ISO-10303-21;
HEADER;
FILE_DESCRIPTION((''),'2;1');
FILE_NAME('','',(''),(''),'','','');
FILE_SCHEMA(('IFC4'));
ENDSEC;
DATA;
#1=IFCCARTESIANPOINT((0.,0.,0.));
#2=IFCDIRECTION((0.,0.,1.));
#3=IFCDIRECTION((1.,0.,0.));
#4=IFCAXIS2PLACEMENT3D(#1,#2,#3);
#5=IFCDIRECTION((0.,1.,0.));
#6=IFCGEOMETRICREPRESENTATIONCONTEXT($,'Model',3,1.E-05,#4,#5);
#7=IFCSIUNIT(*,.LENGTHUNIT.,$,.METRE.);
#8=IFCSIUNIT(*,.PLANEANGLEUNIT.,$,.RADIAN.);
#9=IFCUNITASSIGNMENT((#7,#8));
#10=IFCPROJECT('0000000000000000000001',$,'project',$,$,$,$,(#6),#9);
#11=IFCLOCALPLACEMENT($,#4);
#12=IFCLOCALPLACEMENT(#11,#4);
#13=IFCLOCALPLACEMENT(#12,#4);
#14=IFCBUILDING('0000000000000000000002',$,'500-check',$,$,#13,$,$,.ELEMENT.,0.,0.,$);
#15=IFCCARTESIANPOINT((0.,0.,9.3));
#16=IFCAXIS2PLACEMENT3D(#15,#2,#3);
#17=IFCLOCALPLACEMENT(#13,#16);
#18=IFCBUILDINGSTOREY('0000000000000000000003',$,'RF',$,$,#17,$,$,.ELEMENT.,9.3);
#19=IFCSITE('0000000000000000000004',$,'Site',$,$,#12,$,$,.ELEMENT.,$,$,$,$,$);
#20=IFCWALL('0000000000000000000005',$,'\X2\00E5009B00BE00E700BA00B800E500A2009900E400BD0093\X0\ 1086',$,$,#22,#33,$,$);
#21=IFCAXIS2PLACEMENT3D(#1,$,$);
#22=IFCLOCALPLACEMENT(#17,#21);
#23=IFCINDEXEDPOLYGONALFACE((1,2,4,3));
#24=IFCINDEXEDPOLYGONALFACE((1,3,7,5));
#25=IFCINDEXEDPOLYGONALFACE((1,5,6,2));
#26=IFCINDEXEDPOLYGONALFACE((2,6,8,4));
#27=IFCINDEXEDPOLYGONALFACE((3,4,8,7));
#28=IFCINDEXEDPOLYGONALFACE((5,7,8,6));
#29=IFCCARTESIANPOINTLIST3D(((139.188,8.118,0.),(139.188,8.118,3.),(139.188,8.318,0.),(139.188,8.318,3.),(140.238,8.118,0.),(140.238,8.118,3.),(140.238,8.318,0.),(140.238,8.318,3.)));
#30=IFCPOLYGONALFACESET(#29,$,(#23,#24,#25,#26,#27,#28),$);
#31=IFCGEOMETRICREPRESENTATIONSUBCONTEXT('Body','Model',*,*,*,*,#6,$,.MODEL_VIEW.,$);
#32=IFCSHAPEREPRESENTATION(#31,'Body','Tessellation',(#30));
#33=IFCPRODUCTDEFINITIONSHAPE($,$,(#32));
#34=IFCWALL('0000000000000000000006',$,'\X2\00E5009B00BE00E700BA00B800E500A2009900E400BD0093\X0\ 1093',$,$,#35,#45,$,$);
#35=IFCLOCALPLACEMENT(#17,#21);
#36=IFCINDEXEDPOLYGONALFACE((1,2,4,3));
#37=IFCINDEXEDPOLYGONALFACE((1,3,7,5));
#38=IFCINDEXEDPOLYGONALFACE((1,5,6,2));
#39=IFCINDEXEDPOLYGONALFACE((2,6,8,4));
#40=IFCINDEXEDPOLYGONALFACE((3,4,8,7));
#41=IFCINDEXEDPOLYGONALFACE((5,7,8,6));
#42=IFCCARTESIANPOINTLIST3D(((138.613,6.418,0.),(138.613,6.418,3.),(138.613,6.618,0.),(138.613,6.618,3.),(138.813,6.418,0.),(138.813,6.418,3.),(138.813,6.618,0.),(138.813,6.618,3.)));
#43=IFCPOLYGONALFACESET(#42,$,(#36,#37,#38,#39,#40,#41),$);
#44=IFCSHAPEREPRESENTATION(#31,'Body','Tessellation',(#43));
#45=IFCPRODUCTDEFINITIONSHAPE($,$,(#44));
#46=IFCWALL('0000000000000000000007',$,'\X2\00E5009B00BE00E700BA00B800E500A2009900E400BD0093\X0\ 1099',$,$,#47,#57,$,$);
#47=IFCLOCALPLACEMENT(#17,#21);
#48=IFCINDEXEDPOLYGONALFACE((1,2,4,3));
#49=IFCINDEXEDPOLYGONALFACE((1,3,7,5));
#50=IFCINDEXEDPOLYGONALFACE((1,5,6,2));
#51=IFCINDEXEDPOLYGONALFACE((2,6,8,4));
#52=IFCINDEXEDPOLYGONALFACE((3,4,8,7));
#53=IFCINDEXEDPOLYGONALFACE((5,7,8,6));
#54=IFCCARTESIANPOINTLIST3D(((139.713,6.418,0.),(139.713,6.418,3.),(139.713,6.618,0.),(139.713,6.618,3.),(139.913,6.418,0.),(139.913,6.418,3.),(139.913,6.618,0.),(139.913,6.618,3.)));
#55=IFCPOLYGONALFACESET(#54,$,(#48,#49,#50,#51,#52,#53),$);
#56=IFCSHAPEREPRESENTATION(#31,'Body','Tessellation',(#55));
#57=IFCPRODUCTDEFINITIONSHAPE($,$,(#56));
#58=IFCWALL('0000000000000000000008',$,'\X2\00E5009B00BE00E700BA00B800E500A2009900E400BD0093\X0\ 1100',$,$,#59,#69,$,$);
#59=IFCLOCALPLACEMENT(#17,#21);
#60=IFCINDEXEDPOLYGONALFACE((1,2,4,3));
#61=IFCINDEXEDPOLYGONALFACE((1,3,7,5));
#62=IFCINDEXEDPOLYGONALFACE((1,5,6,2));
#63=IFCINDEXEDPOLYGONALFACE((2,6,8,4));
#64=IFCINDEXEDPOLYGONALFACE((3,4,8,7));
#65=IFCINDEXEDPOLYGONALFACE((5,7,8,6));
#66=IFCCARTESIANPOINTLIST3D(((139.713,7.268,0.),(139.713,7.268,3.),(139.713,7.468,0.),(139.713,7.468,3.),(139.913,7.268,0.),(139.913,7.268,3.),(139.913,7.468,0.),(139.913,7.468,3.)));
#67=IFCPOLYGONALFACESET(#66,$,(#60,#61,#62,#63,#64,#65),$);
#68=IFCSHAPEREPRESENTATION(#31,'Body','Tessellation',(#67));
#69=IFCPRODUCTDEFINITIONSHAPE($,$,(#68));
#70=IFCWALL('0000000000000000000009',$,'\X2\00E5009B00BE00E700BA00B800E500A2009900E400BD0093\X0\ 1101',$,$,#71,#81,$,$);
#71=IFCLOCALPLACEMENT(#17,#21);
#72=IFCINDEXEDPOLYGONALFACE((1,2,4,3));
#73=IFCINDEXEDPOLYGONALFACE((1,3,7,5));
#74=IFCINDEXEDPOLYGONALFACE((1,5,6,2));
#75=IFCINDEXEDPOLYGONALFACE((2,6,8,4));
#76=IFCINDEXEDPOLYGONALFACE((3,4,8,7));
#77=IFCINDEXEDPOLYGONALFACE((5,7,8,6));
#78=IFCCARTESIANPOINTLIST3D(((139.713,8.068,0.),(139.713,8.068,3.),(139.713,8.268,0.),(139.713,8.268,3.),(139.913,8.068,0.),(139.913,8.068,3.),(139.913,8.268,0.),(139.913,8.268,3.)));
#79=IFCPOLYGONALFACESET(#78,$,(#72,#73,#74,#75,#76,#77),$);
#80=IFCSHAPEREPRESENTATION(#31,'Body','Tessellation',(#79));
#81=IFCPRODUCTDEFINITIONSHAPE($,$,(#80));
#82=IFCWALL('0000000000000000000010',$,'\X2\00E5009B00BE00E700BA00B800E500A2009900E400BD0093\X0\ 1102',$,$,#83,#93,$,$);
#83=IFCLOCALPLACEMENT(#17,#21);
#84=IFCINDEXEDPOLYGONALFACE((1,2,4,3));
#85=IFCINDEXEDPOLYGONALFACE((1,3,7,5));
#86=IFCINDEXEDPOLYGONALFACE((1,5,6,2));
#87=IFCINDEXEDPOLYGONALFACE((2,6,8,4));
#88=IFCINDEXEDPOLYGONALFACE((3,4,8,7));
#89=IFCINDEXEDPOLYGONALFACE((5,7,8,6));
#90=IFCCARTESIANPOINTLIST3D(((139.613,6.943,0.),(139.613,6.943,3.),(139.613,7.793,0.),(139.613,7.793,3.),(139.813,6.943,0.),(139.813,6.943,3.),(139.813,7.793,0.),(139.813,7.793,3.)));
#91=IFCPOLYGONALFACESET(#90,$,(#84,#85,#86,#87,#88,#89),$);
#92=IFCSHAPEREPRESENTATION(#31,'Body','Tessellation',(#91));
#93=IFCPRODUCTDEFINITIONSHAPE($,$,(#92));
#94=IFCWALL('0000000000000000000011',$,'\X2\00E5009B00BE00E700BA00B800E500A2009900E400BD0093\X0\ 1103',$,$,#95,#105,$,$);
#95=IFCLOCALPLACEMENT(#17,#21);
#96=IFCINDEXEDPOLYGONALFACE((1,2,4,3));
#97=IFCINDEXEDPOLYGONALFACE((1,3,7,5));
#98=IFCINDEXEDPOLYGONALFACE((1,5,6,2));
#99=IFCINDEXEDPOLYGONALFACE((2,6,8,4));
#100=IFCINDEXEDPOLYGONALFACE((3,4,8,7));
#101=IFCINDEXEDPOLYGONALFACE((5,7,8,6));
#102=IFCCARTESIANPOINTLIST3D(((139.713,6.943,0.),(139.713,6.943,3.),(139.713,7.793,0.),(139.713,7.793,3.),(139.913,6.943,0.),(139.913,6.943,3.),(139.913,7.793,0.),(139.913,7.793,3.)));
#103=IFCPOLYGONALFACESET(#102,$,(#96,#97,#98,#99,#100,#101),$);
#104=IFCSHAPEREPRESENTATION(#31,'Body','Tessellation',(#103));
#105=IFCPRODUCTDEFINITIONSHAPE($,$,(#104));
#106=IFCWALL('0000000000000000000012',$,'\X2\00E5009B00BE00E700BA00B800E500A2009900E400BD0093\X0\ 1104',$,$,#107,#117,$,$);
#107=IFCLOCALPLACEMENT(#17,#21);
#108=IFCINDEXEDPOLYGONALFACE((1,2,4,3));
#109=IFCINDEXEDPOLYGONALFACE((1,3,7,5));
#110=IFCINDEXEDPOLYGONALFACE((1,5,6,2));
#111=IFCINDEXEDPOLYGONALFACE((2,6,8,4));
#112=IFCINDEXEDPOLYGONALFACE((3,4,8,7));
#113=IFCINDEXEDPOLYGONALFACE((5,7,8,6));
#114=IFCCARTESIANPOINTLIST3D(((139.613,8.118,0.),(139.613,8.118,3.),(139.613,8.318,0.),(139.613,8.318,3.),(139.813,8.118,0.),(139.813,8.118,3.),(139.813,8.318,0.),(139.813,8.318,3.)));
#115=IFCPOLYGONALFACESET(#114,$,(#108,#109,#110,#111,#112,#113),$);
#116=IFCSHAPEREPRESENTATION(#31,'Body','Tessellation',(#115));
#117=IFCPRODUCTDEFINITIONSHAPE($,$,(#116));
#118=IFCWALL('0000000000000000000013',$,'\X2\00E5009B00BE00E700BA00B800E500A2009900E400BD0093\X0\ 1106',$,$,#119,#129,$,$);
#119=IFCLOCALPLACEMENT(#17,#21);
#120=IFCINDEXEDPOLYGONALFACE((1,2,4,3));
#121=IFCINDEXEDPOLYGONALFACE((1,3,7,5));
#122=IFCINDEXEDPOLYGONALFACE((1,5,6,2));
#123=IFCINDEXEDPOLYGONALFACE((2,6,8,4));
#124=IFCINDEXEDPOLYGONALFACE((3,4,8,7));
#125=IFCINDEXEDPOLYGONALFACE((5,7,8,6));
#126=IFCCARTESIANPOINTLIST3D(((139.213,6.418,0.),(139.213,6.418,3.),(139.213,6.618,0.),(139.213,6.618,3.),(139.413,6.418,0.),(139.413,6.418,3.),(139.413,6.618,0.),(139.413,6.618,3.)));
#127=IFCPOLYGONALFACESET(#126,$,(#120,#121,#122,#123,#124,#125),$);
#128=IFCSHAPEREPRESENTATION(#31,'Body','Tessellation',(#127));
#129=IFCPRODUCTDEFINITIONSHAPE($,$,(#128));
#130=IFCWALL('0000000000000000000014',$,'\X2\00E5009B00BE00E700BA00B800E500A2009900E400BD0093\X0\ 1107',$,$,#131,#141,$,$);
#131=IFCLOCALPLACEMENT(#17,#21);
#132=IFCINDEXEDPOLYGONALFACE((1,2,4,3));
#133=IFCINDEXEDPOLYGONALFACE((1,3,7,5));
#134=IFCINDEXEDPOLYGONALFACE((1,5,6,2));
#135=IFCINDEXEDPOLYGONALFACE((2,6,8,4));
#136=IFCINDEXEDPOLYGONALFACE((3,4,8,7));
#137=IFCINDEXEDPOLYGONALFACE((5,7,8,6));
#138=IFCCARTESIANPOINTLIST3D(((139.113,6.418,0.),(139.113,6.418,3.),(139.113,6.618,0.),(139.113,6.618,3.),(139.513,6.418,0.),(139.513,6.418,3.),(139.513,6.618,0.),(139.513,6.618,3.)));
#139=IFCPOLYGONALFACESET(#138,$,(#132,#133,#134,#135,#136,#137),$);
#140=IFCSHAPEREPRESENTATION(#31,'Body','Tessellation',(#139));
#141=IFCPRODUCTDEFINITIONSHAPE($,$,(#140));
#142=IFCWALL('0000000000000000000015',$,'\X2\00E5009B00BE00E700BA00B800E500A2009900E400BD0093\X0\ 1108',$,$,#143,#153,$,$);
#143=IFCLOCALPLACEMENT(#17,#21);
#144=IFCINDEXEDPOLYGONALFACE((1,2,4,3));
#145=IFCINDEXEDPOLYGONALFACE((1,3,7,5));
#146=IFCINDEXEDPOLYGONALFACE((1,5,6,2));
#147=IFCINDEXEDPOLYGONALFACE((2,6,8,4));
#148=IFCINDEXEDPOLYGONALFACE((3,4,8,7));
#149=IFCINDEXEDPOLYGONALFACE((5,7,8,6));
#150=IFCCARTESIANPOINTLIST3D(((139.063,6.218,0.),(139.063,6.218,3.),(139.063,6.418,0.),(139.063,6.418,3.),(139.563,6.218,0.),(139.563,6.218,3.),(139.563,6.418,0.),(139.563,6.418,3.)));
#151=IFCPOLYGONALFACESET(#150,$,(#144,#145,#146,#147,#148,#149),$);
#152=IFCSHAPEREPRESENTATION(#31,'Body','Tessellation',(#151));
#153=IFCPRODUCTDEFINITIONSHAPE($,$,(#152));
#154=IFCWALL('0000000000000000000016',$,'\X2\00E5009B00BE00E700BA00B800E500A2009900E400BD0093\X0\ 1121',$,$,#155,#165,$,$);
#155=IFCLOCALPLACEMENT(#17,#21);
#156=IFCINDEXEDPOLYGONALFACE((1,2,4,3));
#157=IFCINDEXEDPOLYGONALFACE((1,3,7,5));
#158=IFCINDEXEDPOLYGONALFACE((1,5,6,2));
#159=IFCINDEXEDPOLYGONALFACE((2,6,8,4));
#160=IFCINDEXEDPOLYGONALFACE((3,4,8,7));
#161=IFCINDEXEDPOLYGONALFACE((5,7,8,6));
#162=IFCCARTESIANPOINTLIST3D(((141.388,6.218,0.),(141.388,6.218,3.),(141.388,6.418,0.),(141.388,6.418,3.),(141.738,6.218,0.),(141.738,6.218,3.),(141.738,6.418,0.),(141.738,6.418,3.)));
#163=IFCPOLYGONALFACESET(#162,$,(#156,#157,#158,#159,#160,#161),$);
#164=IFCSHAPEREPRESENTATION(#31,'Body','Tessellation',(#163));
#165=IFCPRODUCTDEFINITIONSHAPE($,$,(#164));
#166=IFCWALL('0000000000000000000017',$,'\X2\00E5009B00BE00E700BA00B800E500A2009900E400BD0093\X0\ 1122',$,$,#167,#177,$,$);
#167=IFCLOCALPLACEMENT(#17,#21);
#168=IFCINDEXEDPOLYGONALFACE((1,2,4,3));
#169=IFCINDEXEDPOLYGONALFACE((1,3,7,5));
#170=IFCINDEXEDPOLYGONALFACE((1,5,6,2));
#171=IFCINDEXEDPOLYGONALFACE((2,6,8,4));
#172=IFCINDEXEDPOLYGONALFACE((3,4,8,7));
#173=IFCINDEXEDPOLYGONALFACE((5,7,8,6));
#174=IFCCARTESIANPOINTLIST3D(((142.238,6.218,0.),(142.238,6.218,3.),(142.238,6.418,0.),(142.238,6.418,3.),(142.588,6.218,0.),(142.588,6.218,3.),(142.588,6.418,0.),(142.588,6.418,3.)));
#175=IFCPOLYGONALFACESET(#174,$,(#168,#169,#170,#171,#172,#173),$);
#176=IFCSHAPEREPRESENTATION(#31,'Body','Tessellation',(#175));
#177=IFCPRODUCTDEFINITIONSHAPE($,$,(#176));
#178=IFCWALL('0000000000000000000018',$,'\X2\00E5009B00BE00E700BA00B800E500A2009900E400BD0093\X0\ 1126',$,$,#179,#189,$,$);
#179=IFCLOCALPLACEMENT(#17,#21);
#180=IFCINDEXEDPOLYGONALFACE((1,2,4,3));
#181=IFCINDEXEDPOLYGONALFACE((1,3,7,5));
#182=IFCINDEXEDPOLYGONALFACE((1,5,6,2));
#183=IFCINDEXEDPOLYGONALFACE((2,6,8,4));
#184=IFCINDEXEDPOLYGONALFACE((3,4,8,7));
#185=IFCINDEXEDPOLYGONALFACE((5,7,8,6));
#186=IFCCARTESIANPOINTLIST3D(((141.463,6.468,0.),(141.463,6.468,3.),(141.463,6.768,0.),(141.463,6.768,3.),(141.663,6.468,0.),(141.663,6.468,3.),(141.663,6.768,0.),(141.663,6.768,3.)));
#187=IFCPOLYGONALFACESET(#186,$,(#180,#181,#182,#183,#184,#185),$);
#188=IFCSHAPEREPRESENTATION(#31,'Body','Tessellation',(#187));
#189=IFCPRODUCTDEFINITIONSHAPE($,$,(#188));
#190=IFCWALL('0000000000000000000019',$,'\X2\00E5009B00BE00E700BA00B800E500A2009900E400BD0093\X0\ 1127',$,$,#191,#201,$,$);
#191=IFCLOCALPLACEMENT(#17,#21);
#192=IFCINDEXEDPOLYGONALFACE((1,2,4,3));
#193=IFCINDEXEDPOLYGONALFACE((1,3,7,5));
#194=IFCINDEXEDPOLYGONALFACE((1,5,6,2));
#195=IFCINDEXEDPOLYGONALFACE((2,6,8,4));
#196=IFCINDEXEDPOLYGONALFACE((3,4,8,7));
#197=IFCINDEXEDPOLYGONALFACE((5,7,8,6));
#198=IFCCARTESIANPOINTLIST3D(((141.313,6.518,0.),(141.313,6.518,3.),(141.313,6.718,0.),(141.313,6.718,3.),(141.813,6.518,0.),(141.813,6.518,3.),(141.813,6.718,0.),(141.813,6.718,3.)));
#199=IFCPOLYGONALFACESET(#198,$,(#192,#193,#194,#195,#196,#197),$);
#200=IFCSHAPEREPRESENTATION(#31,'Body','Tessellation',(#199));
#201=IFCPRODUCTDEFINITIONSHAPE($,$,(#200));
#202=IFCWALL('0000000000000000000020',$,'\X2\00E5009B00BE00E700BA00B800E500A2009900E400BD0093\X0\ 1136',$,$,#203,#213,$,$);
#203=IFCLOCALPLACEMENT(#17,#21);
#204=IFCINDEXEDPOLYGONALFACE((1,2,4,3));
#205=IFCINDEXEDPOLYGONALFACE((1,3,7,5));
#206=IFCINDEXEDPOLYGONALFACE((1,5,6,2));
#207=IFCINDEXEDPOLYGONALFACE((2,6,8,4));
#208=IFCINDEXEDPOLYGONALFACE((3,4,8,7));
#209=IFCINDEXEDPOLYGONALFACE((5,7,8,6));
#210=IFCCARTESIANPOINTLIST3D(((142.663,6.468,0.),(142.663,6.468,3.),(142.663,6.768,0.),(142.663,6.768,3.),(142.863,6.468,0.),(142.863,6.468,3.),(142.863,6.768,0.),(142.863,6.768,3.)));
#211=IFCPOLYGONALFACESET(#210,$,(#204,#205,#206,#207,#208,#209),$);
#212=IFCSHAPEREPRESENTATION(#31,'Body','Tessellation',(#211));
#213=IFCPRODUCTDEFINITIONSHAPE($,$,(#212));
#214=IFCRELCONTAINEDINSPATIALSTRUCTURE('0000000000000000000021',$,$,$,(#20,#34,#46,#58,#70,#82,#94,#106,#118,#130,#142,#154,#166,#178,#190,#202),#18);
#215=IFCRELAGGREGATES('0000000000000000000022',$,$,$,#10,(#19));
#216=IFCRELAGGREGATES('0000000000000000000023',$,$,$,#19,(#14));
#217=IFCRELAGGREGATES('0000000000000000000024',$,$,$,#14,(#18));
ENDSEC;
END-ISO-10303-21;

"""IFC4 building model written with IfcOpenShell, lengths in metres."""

from ifc_helpers import new_model, si_unit, direction, frame, frame_2d, origin_with_axes, place, context, subcontext, project, spatial, rectangle, extrude, element, save


model = new_model("IFC4")

# Units and contexts
model_context = context("Model", 3, precision=1e-05, world=origin_with_axes(), true_north=direction((0.0, 1.0, 0.0)))
body_context = subcontext(model_context, "Body", "Model", "MODEL_VIEW")
ifc_project = project(units=[si_unit("LENGTHUNIT", "METRE"), si_unit("PLANEANGLEUNIT", "RADIAN")], contexts=[model_context])

# Site, building, storey
placement = place(None, origin_with_axes())
site_placement = place(placement, origin_with_axes())
site = spatial("IfcSite", under=ifc_project, at=site_placement, Name="Site", CompositionType="ELEMENT")
building_placement = place(site_placement, origin_with_axes())
building = spatial("IfcBuilding", under=site, at=building_placement, Name="500-check", CompositionType="ELEMENT", ElevationOfRefHeight=0.0, ElevationOfTerrain=0.0)
storey_placement = place(building_placement, frame((0.0, 0.0, 9.3), z_axis=(0.0, 0.0, 1.0), x_axis=(1.0, 0.0, 0.0)))
storey = spatial("IfcBuildingStorey", under=building, at=storey_placement, Name="RF", CompositionType="ELEMENT", Elevation=9.3)

# Walls
wall_1_placement = place(storey_placement, frame((139.713, 8.218, 0.0), z_axis=(0.0, 0.0, 1.0), x_axis=(-1.0, 0.0, 0.0)))
element("IfcWall", 1, at=wall_1_placement, inside=storey, Name="å\u009b¾çº¸å¢\u0099ä½\u0093 1086", context=body_context, shape_type="SweptSolid", body=[
    extrude(rectangle(XDim=1.05, YDim=0.2, at=frame_2d((0.0, 0.0), x_axis=(1.0, 0.0, 0.0))), frame((0.0, 0.0, 0.0), z_axis=(0.0, 0.0, 1.0)), (0.0, 0.0, 1.0), 3.0),
])
for number, where, z_axis, x_axis, name in (
    (2, (138.713, 6.518, 0.0), (0.0, 0.0, 1.0), (0.0, -1.0, 0.0), "å\u009b¾çº¸å¢\u0099ä½\u0093 1093"),
    (3, (139.813, 6.518, 0.0), (0.0, 0.0, 1.0), (0.0, -1.0, 0.0), "å\u009b¾çº¸å¢\u0099ä½\u0093 1099"),
    (4, (139.813, 7.368, 0.0), (0.0, 0.0, 1.0), (-1.0, 0.0, 0.0), "å\u009b¾çº¸å¢\u0099ä½\u0093 1100"),
    (5, (139.813, 8.168, 0.0), (0.0, 0.0, 1.0), (-1.0, 0.0, 0.0), "å\u009b¾çº¸å¢\u0099ä½\u0093 1101"),
):
    element("IfcWall", number, at=place(storey_placement, frame(where, z_axis=z_axis, x_axis=x_axis)), inside=storey, Name=name, context=body_context, shape_type="SweptSolid", body=[
        extrude(rectangle(XDim=0.2, YDim=0.2, at=frame_2d((0.0, 0.0), x_axis=(1.0, 0.0, 0.0))), frame((0.0, 0.0, 0.0), z_axis=(0.0, 0.0, 1.0)), (0.0, 0.0, 1.0), 3.0),
    ])
for number, where, z_axis, x_axis, name in (
    (6, (139.713, 7.368, 0.0), (0.0, 0.0, 1.0), (0.0, -1.0, 0.0), "å\u009b¾çº¸å¢\u0099ä½\u0093 1102"),
    (7, (139.813, 7.368, 0.0), (0.0, 0.0, 1.0), (0.0, -1.0, 0.0), "å\u009b¾çº¸å¢\u0099ä½\u0093 1103"),
):
    element("IfcWall", number, at=place(storey_placement, frame(where, z_axis=z_axis, x_axis=x_axis)), inside=storey, Name=name, context=body_context, shape_type="SweptSolid", body=[
        extrude(rectangle(XDim=0.85, YDim=0.2, at=frame_2d((0.0, 0.0), x_axis=(1.0, 0.0, 0.0))), frame((0.0, 0.0, 0.0), z_axis=(0.0, 0.0, 1.0)), (0.0, 0.0, 1.0), 3.0),
    ])
for number, where, z_axis, x_axis, name in (
    (8, (139.713, 8.218, 0.0), (0.0, 0.0, 1.0), (0.0, -1.0, 0.0), "å\u009b¾çº¸å¢\u0099ä½\u0093 1104"),
    (9, (139.313, 6.518, 0.0), (0.0, 0.0, 1.0), (0.0, -1.0, 0.0), "å\u009b¾çº¸å¢\u0099ä½\u0093 1106"),
):
    element("IfcWall", number, at=place(storey_placement, frame(where, z_axis=z_axis, x_axis=x_axis)), inside=storey, Name=name, context=body_context, shape_type="SweptSolid", body=[
        extrude(rectangle(XDim=0.2, YDim=0.2, at=frame_2d((0.0, 0.0), x_axis=(1.0, 0.0, 0.0))), frame((0.0, 0.0, 0.0), z_axis=(0.0, 0.0, 1.0)), (0.0, 0.0, 1.0), 3.0),
    ])
wall_2_placement = place(storey_placement, frame((139.313, 6.518, 0.0), z_axis=(0.0, 0.0, 1.0), x_axis=(1.0, 0.0, 0.0)))
element("IfcWall", 10, at=wall_2_placement, inside=storey, Name="å\u009b¾çº¸å¢\u0099ä½\u0093 1107", context=body_context, shape_type="SweptSolid", body=[
    extrude(rectangle(XDim=0.4, YDim=0.2, at=frame_2d((0.0, 0.0), x_axis=(1.0, 0.0, 0.0))), frame((0.0, 0.0, 0.0), z_axis=(0.0, 0.0, 1.0)), (0.0, 0.0, 1.0), 3.0),
])
wall_3_placement = place(storey_placement, frame((139.313, 6.318, 0.0), z_axis=(0.0, 0.0, 1.0), x_axis=(1.0, 0.0, 0.0)))
element("IfcWall", 11, at=wall_3_placement, inside=storey, Name="å\u009b¾çº¸å¢\u0099ä½\u0093 1108", context=body_context, shape_type="SweptSolid", body=[
    extrude(rectangle(XDim=0.5, YDim=0.2, at=frame_2d((0.0, 0.0), x_axis=(1.0, 0.0, 0.0))), frame((0.0, 0.0, 0.0), z_axis=(0.0, 0.0, 1.0)), (0.0, 0.0, 1.0), 3.0),
])
for number, where, z_axis, x_axis, name in (
    (12, (141.563, 6.318, 0.0), (0.0, 0.0, 1.0), (1.0, 0.0, 0.0), "å\u009b¾çº¸å¢\u0099ä½\u0093 1121"),
    (13, (142.413, 6.318, 0.0), (0.0, 0.0, 1.0), (1.0, 0.0, 0.0), "å\u009b¾çº¸å¢\u0099ä½\u0093 1122"),
):
    element("IfcWall", number, at=place(storey_placement, frame(where, z_axis=z_axis, x_axis=x_axis)), inside=storey, Name=name, context=body_context, shape_type="SweptSolid", body=[
        extrude(rectangle(XDim=0.35, YDim=0.2, at=frame_2d((0.0, 0.0), x_axis=(1.0, 0.0, 0.0))), frame((0.0, 0.0, 0.0), z_axis=(0.0, 0.0, 1.0)), (0.0, 0.0, 1.0), 3.0),
    ])
wall_4_placement = place(storey_placement, frame((141.563, 6.618, 0.0), z_axis=(0.0, 0.0, 1.0), x_axis=(0.0, -1.0, 0.0)))
element("IfcWall", 14, at=wall_4_placement, inside=storey, Name="å\u009b¾çº¸å¢\u0099ä½\u0093 1126", context=body_context, shape_type="SweptSolid", body=[
    extrude(rectangle(XDim=0.3, YDim=0.2, at=frame_2d((0.0, 0.0), x_axis=(1.0, 0.0, 0.0))), frame((0.0, 0.0, 0.0), z_axis=(0.0, 0.0, 1.0)), (0.0, 0.0, 1.0), 3.0),
])
wall_5_placement = place(storey_placement, frame((141.563, 6.618, 0.0), z_axis=(0.0, 0.0, 1.0), x_axis=(1.0, 0.0, 0.0)))
element("IfcWall", 15, at=wall_5_placement, inside=storey, Name="å\u009b¾çº¸å¢\u0099ä½\u0093 1127", context=body_context, shape_type="SweptSolid", body=[
    extrude(rectangle(XDim=0.5, YDim=0.2, at=frame_2d((0.0, 0.0), x_axis=(1.0, 0.0, 0.0))), frame((0.0, 0.0, 0.0), z_axis=(0.0, 0.0, 1.0)), (0.0, 0.0, 1.0), 3.0),
])
wall_6_placement = place(storey_placement, frame((142.763, 6.618, 0.0), z_axis=(0.0, 0.0, 1.0), x_axis=(0.0, -1.0, 0.0)))
element("IfcWall", 16, at=wall_6_placement, inside=storey, Name="å\u009b¾çº¸å¢\u0099ä½\u0093 1136", context=body_context, shape_type="SweptSolid", body=[
    extrude(rectangle(XDim=0.3, YDim=0.2, at=frame_2d((0.0, 0.0), x_axis=(1.0, 0.0, 0.0))), frame((0.0, 0.0, 0.0), z_axis=(0.0, 0.0, 1.0)), (0.0, 0.0, 1.0), 3.0),
])

save(model, "model.ifc")
